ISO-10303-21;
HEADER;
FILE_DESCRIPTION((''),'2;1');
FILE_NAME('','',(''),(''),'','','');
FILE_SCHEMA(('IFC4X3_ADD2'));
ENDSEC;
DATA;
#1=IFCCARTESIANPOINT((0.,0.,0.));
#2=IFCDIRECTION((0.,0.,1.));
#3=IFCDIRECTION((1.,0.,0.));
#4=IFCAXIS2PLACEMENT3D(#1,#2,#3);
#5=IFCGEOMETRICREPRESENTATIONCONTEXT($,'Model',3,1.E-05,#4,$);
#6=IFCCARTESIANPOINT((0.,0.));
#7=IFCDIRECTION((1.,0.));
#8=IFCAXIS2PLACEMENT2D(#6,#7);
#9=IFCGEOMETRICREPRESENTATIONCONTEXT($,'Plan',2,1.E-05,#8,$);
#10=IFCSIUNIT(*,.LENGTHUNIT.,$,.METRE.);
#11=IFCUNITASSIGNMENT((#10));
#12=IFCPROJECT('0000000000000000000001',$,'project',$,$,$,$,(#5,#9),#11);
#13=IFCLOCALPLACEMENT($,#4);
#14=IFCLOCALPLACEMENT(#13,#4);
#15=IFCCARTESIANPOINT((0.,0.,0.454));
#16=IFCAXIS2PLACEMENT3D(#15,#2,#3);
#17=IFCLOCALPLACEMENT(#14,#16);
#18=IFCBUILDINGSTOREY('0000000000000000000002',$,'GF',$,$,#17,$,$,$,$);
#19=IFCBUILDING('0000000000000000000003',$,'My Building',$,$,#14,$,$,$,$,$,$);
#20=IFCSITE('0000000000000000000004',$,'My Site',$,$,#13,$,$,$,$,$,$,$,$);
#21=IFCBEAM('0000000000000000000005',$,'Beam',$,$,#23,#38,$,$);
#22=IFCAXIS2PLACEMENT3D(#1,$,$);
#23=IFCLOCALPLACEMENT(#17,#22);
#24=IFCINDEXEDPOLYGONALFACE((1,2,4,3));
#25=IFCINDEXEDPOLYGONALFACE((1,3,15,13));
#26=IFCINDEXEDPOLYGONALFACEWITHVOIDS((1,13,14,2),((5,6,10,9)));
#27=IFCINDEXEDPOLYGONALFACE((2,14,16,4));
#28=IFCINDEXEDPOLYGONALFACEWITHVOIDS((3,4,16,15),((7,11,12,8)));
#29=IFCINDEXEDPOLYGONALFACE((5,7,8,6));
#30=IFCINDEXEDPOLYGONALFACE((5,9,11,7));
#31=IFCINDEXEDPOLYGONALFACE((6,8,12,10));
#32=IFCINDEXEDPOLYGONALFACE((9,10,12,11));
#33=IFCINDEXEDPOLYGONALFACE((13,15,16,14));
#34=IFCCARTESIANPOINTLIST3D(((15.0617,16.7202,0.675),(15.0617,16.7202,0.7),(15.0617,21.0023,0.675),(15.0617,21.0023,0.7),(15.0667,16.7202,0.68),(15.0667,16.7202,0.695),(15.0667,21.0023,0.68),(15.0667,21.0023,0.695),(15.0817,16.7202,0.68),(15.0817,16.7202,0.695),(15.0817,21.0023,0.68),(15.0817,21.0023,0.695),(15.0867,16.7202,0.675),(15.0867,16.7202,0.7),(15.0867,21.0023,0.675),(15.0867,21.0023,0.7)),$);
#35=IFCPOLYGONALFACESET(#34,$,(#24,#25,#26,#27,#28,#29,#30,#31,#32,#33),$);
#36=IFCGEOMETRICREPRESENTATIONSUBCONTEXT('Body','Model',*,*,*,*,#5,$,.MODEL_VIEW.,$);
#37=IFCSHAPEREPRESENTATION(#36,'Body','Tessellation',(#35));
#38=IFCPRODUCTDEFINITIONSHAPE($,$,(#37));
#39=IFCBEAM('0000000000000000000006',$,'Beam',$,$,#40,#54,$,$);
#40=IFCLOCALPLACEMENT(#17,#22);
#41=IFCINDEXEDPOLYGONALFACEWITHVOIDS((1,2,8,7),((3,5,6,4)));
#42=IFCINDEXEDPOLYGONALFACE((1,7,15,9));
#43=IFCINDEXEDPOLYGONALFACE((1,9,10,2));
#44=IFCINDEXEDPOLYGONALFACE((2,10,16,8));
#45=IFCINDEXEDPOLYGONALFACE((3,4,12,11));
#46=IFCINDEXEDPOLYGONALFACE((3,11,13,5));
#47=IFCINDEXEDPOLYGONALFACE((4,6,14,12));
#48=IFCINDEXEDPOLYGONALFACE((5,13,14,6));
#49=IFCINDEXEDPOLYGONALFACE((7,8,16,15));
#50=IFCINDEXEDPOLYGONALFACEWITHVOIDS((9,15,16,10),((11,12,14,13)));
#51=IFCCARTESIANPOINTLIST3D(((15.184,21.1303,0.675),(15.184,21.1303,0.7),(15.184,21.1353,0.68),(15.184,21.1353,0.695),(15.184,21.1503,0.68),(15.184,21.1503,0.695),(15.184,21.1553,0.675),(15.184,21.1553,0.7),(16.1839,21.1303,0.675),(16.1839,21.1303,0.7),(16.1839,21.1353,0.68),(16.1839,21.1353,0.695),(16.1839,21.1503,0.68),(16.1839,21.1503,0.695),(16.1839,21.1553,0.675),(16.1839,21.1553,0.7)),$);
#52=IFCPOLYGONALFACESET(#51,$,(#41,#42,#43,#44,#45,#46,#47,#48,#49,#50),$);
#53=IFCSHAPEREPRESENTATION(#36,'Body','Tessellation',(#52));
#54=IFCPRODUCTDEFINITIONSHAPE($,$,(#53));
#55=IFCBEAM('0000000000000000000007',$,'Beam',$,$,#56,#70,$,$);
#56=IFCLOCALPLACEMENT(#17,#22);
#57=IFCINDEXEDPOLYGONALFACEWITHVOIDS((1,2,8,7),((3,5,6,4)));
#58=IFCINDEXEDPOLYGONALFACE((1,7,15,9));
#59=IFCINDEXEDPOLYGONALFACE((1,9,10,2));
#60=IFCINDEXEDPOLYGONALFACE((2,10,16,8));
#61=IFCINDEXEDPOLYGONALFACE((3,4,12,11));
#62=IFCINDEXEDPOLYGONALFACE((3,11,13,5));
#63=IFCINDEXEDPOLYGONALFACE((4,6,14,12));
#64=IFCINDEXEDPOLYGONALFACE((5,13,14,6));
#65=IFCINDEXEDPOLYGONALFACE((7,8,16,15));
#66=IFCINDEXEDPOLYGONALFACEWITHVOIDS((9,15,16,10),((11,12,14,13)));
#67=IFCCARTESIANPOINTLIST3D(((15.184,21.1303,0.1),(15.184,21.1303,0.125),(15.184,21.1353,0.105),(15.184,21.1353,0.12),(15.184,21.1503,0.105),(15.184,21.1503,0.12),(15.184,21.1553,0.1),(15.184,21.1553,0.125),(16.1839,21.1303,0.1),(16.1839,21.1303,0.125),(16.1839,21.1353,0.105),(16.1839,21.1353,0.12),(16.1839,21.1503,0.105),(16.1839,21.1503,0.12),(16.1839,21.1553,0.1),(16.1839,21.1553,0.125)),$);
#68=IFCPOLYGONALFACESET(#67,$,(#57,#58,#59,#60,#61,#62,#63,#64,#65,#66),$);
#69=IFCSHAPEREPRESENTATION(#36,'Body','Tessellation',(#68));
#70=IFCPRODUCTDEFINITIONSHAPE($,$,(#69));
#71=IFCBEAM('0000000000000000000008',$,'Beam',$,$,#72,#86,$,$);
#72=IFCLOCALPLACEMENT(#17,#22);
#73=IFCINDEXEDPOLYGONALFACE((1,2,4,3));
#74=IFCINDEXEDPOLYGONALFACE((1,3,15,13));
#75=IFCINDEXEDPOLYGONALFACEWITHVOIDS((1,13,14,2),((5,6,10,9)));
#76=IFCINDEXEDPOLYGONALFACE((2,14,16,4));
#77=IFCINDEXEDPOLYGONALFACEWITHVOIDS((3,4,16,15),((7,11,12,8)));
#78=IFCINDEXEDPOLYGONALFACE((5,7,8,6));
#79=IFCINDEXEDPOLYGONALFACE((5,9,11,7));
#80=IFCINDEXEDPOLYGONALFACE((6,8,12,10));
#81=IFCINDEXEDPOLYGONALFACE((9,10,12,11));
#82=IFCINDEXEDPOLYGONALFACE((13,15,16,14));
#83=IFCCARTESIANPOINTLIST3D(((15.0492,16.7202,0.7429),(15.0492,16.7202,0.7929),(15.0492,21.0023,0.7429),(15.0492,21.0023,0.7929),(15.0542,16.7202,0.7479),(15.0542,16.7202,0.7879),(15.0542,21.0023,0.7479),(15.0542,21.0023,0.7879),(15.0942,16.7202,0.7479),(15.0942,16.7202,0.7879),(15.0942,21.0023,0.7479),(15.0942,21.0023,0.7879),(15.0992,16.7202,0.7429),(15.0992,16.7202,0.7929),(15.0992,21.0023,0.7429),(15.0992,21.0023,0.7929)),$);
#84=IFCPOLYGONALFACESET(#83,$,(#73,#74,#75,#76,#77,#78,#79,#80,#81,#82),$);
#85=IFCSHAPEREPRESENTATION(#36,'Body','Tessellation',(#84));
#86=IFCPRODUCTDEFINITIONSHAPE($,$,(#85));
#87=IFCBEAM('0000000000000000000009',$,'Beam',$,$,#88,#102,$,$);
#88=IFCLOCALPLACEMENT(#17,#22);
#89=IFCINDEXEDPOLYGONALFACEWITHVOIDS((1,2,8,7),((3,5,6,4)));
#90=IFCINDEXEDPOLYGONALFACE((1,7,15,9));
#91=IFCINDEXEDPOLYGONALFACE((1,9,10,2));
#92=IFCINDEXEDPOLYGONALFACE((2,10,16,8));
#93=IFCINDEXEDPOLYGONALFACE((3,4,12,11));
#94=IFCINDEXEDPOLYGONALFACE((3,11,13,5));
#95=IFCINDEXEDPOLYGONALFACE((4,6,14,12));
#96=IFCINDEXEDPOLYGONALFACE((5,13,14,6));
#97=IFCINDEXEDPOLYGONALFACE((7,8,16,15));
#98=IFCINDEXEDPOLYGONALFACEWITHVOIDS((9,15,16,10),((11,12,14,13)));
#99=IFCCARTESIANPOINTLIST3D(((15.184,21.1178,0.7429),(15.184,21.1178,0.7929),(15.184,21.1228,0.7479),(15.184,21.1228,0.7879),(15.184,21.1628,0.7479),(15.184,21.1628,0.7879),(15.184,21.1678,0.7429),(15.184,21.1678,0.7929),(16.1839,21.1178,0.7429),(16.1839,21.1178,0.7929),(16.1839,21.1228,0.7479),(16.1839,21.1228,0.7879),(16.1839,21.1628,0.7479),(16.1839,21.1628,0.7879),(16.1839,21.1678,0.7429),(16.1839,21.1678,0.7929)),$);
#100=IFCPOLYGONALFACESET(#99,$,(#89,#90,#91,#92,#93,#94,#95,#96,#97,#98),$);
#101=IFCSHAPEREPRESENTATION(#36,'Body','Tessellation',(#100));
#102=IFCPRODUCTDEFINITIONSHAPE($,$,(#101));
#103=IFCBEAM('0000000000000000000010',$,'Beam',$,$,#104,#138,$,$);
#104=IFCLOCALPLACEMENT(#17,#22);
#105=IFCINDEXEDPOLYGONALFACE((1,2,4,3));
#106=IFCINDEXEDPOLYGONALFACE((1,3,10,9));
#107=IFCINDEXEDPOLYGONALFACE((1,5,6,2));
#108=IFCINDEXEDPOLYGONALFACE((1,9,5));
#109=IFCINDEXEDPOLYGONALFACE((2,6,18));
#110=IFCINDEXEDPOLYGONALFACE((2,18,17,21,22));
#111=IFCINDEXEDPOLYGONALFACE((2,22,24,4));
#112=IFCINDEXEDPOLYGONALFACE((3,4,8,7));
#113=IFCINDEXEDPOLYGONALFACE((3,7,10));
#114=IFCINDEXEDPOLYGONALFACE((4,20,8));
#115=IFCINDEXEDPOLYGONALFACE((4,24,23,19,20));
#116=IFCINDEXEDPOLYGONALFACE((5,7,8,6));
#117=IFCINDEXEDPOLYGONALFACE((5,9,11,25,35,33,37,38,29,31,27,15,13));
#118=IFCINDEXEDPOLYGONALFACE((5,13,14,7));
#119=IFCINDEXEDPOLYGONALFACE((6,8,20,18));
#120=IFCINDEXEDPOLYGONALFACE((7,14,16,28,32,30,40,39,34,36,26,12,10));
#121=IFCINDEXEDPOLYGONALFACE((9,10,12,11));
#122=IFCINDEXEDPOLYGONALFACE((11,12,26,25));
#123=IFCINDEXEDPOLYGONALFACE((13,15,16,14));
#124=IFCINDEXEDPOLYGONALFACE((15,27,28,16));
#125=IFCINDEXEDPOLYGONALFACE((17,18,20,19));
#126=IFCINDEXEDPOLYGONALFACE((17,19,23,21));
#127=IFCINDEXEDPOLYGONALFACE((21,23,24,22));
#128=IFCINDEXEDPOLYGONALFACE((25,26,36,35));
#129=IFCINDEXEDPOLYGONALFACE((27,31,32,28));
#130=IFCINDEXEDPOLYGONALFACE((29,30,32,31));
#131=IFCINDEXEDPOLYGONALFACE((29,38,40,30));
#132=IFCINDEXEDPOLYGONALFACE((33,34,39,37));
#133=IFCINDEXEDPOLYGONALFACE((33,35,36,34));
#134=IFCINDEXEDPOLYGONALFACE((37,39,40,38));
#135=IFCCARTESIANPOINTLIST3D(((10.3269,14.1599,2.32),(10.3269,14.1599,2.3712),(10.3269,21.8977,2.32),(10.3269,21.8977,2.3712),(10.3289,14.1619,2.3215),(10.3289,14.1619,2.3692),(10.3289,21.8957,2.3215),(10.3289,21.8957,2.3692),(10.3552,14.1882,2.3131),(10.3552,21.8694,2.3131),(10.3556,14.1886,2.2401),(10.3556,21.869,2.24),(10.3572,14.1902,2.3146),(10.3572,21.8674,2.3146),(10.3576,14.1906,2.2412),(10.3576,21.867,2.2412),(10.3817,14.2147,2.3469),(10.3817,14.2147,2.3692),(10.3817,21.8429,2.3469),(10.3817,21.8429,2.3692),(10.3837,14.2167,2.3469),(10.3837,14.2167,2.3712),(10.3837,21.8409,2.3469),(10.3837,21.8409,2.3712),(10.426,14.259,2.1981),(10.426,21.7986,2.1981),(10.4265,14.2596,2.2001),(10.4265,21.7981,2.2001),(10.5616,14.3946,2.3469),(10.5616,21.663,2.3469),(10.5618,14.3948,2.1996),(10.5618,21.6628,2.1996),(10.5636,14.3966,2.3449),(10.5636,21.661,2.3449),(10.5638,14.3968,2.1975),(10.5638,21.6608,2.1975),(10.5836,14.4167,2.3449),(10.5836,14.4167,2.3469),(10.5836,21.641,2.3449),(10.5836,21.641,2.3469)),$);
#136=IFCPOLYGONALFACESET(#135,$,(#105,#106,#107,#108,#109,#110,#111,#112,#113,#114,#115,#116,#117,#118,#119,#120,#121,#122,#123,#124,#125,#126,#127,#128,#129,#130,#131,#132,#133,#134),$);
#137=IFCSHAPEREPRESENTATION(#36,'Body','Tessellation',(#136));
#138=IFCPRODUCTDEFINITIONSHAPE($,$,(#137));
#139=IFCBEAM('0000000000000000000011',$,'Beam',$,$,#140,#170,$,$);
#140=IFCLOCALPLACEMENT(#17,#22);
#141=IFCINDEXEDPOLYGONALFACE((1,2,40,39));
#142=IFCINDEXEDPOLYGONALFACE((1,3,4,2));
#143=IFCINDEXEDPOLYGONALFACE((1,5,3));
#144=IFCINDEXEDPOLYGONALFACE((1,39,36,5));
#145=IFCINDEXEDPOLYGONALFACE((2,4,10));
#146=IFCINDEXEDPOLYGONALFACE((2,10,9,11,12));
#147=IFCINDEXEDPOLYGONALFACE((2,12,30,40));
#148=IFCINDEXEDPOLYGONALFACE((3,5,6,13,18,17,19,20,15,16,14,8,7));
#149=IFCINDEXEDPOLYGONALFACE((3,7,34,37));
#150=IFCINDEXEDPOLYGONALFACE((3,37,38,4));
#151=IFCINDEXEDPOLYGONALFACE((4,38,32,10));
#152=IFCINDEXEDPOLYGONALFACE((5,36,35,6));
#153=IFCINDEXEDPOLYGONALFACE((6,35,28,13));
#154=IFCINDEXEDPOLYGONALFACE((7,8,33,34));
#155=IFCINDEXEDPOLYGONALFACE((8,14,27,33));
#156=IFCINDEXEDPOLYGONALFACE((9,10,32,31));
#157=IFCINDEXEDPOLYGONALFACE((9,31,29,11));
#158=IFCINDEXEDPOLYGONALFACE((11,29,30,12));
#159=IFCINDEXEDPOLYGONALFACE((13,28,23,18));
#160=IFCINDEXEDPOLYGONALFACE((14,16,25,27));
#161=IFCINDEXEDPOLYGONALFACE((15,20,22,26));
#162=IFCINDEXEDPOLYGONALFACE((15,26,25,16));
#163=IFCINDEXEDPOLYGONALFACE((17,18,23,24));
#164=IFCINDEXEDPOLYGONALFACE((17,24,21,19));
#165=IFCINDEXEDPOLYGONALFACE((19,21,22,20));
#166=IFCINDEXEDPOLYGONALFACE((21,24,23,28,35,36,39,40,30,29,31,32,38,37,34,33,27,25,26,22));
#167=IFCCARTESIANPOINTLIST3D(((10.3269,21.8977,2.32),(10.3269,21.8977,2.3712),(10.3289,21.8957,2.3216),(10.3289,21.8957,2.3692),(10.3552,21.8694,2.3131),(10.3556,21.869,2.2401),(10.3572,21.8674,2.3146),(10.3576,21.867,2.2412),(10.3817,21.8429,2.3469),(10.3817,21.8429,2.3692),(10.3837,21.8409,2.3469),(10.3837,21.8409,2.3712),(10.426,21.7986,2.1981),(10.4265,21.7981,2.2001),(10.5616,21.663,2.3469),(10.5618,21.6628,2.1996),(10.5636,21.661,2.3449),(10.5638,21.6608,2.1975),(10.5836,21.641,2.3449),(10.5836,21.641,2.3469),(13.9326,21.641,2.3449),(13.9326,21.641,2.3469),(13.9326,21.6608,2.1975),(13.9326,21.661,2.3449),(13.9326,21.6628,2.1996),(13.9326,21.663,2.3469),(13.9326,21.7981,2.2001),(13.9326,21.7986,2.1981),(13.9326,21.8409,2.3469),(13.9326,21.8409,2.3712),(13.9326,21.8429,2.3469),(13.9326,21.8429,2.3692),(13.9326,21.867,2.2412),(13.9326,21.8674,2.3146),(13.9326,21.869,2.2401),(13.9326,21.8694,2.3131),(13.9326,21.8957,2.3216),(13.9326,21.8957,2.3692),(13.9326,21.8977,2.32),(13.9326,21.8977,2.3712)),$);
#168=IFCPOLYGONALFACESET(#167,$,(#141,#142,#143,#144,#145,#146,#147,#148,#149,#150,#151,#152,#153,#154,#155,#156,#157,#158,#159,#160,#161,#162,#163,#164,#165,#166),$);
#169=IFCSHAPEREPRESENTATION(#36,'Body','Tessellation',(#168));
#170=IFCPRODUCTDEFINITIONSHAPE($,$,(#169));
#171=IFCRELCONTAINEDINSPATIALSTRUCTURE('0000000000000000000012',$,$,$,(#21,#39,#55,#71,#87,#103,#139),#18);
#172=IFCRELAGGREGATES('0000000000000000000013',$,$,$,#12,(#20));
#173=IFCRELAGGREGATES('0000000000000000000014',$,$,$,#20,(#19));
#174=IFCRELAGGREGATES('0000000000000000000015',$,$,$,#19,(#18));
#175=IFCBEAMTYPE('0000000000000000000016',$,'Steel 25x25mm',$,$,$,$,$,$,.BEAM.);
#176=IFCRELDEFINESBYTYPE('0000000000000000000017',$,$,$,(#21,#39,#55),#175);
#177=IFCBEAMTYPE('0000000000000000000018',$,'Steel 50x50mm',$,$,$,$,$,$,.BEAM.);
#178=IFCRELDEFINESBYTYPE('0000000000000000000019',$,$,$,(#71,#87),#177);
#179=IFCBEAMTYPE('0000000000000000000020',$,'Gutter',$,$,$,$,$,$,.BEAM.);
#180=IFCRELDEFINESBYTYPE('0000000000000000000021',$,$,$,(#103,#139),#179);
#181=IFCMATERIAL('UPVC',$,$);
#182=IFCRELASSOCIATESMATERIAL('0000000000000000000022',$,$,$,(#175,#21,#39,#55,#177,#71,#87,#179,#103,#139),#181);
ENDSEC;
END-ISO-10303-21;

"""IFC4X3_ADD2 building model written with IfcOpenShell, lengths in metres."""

from ifc_helpers import new_model, si_unit, frame, origin_with_axes, origin_2d_with_axis, place, context, subcontext, project, spatial, indexed_curve, hollow_rectangle, outline, extrude, clip, halfspace, material, material_profile, profile_set, profile_usage, type_object, element, save


model = new_model("IFC4X3_ADD2")

# Units and contexts
model_context = context("Model", 3, precision=1e-05, world=origin_with_axes())
plan_context = context("Plan", 2, precision=1e-05, world=origin_2d_with_axis())
body_context = subcontext(model_context, "Body", "Model", "MODEL_VIEW")
ifc_project = project(units=[si_unit("LENGTHUNIT", "METRE")], contexts=[model_context, plan_context])

# Site, building, storey
site_placement = place(None, origin_with_axes())
site = spatial("IfcSite", under=ifc_project, at=site_placement, Name="My Site")
building_placement = place(site_placement, origin_with_axes())
building = spatial("IfcBuilding", under=site, at=building_placement, Name="My Building")
storey_placement = place(building_placement, frame((0.0, 0.0, 0.454), z_axis=(0.0, 0.0, 1.0), x_axis=(1.0, 0.0, 0.0)))
storey = spatial("IfcBuildingStorey", under=building, at=storey_placement, Name="GF")

# Shared definitions
ifc_material_1 = material(Name="UPVC")

# Beams
ifc_material_profile_1 = material_profile(ifc_material_1, hollow_rectangle(XDim=0.025, YDim=0.025, WallThickness=0.005))
ifc_profile_set_1 = profile_set([ifc_material_profile_1])
beam_type_1 = type_object("IfcBeamType", Name="Steel 25x25mm", PredefinedType="BEAM", material=ifc_profile_set_1)
ifc_profile_usage_1 = profile_usage(ifc_profile_set_1)
beam_1_placement = place(storey_placement, frame((15.0742, 21.0023, 0.6875), z_axis=(0.0, -1.0, 0.0), x_axis=(1.0, 0.0, 0.0)))
element("IfcBeam", 1, at=beam_1_placement, inside=storey, type_object=beam_type_1, material=ifc_profile_usage_1, Name="Beam", context=body_context, shape_type="SweptSolid", body=[
    extrude(hollow_rectangle(XDim=0.025, YDim=0.025, WallThickness=0.005), origin_with_axes(), (0.0, 0.0, 1.0), 4.2821),
])
ifc_profile_usage_2 = profile_usage(ifc_profile_set_1)
beam_2_placement = place(storey_placement, frame((15.184, 21.1428, 0.6875), z_axis=(1.0, 0.0, 0.0), x_axis=(0.0, 1.0, 0.0)))
element("IfcBeam", 2, at=beam_2_placement, inside=storey, type_object=beam_type_1, material=ifc_profile_usage_2, Name="Beam", context=body_context, shape_type="SweptSolid", body=[
    extrude(hollow_rectangle(XDim=0.025, YDim=0.025, WallThickness=0.005), origin_with_axes(), (0.0, 0.0, 1.0), 1.0),
])
ifc_profile_usage_3 = profile_usage(ifc_profile_set_1)
beam_3_placement = place(storey_placement, frame((15.184, 21.1428, 0.1125), z_axis=(1.0, 0.0, 0.0), x_axis=(0.0, 1.0, 0.0)))
element("IfcBeam", 3, at=beam_3_placement, inside=storey, type_object=beam_type_1, material=ifc_profile_usage_3, Name="Beam", context=body_context, shape_type="SweptSolid", body=[
    extrude(hollow_rectangle(XDim=0.025, YDim=0.025, WallThickness=0.005), origin_with_axes(), (0.0, 0.0, 1.0), 1.0),
])
ifc_material_profile_2 = material_profile(ifc_material_1, hollow_rectangle(XDim=0.05, YDim=0.05, WallThickness=0.005))
ifc_profile_set_2 = profile_set([ifc_material_profile_2])
ifc_profile_usage_4 = profile_usage(ifc_profile_set_2)
beam_type_2 = type_object("IfcBeamType", Name="Steel 50x50mm", PredefinedType="BEAM", material=ifc_profile_set_2)
beam_4_placement = place(storey_placement, frame((15.0742, 21.0023, 0.7679), z_axis=(0.0, -1.0, 0.0), x_axis=(1.0, 0.0, 0.0)))
element("IfcBeam", 4, at=beam_4_placement, inside=storey, type_object=beam_type_2, material=ifc_profile_usage_4, Name="Beam", context=body_context, shape_type="SweptSolid", body=[
    extrude(hollow_rectangle(XDim=0.05, YDim=0.05, WallThickness=0.005), origin_with_axes(), (0.0, 0.0, 1.0), 4.2821),
])
ifc_profile_usage_5 = profile_usage(ifc_profile_set_2)
beam_5_placement = place(storey_placement, frame((15.184, 21.1428, 0.7679), z_axis=(1.0, 0.0, 0.0), x_axis=(0.0, 1.0, 0.0)))
element("IfcBeam", 5, at=beam_5_placement, inside=storey, type_object=beam_type_2, material=ifc_profile_usage_5, Name="Beam", context=body_context, shape_type="SweptSolid", body=[
    extrude(hollow_rectangle(XDim=0.05, YDim=0.05, WallThickness=0.005), origin_with_axes(), (0.0, 0.0, 1.0), 1.0),
])
ifc_material_profile_3 = material_profile(ifc_material_1, outline(indexed_curve([(0.0548, 0.1717), (0.002, 0.1717), (0.002, 0.124), (0.0303, 0.1171), (0.0307, 0.0436), (0.0996, 0.0025), (0.2349, 0.002), (0.2347, 0.1494), (0.2567, 0.1494), (0.2567, 0.1474), (0.2367, 0.1474), (0.2369, 0.0), (0.0991, 0.0005), (0.0287, 0.0425), (0.0283, 0.1155), (0.0, 0.1224), (0.0, 0.1737), (0.0568, 0.1737), (0.0568, 0.1494), (0.0548, 0.1494), (0.0548, 0.1717)])))
ifc_profile_set_3 = profile_set([ifc_material_profile_3])
ifc_profile_usage_6 = profile_usage(ifc_profile_set_3)
beam_type_3 = type_object("IfcBeamType", Name="Gutter", PredefinedType="BEAM", material=ifc_profile_set_3)
beam_6_placement = place(storey_placement, frame((10.3269, 21.8977, 2.1975), z_axis=(0.0, -1.0, 0.0), x_axis=(1.0, 0.0, 0.0)))
element("IfcBeam", 6, at=beam_6_placement, inside=storey, type_object=beam_type_3, material=ifc_profile_usage_6, Name="Beam", context=body_context, shape_type="Clipping", body=[
    clip(clip(extrude(outline(indexed_curve([(0.0548, 0.1717), (0.002, 0.1717), (0.002, 0.124), (0.0303, 0.1171), (0.0307, 0.0436), (0.0996, 0.0025), (0.2349, 0.002), (0.2347, 0.1494), (0.2567, 0.1494), (0.2567, 0.1474), (0.2367, 0.1474), (0.2369, 0.0), (0.0991, 0.0005), (0.0287, 0.0425), (0.0283, 0.1155), (0.0, 0.1224), (0.0, 0.1737), (0.0568, 0.1737), (0.0568, 0.1494), (0.0548, 0.1494), (0.0548, 0.1717)])), origin_with_axes(), (0.0, 0.0, 1.0), 7.7378), halfspace(frame((0.0, -2.6516, 7.7378), z_axis=(0.707107, 0.0, 0.707106), x_axis=(0.0, -1.0, 0.0)), False)), halfspace(frame((0.0, -2.6516, 0.0), z_axis=(0.707106, 0.0, -0.707107), x_axis=(0.0, -1.0, 0.0)), False)),
])
ifc_profile_usage_7 = profile_usage(ifc_profile_set_3)
beam_7_placement = place(storey_placement, frame((13.9326, 21.8977, 2.1975), z_axis=(-1.0, 0.000001, 0.0), x_axis=(-0.000001, -1.0, 0.0)))
element("IfcBeam", 7, at=beam_7_placement, inside=storey, type_object=beam_type_3, material=ifc_profile_usage_7, Name="Beam", context=body_context, shape_type="Clipping", body=[
    clip(extrude(outline(indexed_curve([(0.0548, 0.1717), (0.002, 0.1717), (0.002, 0.124), (0.0303, 0.1171), (0.0307, 0.0436), (0.0996, 0.0025), (0.2349, 0.002), (0.2347, 0.1494), (0.2567, 0.1494), (0.2567, 0.1474), (0.2367, 0.1474), (0.2369, 0.0), (0.0991, 0.0005), (0.0287, 0.0425), (0.0283, 0.1155), (0.0, 0.1224), (0.0, 0.1737), (0.0568, 0.1737), (0.0568, 0.1494), (0.0548, 0.1494), (0.0548, 0.1717)])), origin_with_axes(), (0.0, 0.0, 1.0), 3.6057), halfspace(frame((0.0, -2.3765, 3.6057), z_axis=(0.707107, 0.0, 0.707106), x_axis=(0.0, -1.0, 0.0)), False)),
])

save(model, "model.ifc")
